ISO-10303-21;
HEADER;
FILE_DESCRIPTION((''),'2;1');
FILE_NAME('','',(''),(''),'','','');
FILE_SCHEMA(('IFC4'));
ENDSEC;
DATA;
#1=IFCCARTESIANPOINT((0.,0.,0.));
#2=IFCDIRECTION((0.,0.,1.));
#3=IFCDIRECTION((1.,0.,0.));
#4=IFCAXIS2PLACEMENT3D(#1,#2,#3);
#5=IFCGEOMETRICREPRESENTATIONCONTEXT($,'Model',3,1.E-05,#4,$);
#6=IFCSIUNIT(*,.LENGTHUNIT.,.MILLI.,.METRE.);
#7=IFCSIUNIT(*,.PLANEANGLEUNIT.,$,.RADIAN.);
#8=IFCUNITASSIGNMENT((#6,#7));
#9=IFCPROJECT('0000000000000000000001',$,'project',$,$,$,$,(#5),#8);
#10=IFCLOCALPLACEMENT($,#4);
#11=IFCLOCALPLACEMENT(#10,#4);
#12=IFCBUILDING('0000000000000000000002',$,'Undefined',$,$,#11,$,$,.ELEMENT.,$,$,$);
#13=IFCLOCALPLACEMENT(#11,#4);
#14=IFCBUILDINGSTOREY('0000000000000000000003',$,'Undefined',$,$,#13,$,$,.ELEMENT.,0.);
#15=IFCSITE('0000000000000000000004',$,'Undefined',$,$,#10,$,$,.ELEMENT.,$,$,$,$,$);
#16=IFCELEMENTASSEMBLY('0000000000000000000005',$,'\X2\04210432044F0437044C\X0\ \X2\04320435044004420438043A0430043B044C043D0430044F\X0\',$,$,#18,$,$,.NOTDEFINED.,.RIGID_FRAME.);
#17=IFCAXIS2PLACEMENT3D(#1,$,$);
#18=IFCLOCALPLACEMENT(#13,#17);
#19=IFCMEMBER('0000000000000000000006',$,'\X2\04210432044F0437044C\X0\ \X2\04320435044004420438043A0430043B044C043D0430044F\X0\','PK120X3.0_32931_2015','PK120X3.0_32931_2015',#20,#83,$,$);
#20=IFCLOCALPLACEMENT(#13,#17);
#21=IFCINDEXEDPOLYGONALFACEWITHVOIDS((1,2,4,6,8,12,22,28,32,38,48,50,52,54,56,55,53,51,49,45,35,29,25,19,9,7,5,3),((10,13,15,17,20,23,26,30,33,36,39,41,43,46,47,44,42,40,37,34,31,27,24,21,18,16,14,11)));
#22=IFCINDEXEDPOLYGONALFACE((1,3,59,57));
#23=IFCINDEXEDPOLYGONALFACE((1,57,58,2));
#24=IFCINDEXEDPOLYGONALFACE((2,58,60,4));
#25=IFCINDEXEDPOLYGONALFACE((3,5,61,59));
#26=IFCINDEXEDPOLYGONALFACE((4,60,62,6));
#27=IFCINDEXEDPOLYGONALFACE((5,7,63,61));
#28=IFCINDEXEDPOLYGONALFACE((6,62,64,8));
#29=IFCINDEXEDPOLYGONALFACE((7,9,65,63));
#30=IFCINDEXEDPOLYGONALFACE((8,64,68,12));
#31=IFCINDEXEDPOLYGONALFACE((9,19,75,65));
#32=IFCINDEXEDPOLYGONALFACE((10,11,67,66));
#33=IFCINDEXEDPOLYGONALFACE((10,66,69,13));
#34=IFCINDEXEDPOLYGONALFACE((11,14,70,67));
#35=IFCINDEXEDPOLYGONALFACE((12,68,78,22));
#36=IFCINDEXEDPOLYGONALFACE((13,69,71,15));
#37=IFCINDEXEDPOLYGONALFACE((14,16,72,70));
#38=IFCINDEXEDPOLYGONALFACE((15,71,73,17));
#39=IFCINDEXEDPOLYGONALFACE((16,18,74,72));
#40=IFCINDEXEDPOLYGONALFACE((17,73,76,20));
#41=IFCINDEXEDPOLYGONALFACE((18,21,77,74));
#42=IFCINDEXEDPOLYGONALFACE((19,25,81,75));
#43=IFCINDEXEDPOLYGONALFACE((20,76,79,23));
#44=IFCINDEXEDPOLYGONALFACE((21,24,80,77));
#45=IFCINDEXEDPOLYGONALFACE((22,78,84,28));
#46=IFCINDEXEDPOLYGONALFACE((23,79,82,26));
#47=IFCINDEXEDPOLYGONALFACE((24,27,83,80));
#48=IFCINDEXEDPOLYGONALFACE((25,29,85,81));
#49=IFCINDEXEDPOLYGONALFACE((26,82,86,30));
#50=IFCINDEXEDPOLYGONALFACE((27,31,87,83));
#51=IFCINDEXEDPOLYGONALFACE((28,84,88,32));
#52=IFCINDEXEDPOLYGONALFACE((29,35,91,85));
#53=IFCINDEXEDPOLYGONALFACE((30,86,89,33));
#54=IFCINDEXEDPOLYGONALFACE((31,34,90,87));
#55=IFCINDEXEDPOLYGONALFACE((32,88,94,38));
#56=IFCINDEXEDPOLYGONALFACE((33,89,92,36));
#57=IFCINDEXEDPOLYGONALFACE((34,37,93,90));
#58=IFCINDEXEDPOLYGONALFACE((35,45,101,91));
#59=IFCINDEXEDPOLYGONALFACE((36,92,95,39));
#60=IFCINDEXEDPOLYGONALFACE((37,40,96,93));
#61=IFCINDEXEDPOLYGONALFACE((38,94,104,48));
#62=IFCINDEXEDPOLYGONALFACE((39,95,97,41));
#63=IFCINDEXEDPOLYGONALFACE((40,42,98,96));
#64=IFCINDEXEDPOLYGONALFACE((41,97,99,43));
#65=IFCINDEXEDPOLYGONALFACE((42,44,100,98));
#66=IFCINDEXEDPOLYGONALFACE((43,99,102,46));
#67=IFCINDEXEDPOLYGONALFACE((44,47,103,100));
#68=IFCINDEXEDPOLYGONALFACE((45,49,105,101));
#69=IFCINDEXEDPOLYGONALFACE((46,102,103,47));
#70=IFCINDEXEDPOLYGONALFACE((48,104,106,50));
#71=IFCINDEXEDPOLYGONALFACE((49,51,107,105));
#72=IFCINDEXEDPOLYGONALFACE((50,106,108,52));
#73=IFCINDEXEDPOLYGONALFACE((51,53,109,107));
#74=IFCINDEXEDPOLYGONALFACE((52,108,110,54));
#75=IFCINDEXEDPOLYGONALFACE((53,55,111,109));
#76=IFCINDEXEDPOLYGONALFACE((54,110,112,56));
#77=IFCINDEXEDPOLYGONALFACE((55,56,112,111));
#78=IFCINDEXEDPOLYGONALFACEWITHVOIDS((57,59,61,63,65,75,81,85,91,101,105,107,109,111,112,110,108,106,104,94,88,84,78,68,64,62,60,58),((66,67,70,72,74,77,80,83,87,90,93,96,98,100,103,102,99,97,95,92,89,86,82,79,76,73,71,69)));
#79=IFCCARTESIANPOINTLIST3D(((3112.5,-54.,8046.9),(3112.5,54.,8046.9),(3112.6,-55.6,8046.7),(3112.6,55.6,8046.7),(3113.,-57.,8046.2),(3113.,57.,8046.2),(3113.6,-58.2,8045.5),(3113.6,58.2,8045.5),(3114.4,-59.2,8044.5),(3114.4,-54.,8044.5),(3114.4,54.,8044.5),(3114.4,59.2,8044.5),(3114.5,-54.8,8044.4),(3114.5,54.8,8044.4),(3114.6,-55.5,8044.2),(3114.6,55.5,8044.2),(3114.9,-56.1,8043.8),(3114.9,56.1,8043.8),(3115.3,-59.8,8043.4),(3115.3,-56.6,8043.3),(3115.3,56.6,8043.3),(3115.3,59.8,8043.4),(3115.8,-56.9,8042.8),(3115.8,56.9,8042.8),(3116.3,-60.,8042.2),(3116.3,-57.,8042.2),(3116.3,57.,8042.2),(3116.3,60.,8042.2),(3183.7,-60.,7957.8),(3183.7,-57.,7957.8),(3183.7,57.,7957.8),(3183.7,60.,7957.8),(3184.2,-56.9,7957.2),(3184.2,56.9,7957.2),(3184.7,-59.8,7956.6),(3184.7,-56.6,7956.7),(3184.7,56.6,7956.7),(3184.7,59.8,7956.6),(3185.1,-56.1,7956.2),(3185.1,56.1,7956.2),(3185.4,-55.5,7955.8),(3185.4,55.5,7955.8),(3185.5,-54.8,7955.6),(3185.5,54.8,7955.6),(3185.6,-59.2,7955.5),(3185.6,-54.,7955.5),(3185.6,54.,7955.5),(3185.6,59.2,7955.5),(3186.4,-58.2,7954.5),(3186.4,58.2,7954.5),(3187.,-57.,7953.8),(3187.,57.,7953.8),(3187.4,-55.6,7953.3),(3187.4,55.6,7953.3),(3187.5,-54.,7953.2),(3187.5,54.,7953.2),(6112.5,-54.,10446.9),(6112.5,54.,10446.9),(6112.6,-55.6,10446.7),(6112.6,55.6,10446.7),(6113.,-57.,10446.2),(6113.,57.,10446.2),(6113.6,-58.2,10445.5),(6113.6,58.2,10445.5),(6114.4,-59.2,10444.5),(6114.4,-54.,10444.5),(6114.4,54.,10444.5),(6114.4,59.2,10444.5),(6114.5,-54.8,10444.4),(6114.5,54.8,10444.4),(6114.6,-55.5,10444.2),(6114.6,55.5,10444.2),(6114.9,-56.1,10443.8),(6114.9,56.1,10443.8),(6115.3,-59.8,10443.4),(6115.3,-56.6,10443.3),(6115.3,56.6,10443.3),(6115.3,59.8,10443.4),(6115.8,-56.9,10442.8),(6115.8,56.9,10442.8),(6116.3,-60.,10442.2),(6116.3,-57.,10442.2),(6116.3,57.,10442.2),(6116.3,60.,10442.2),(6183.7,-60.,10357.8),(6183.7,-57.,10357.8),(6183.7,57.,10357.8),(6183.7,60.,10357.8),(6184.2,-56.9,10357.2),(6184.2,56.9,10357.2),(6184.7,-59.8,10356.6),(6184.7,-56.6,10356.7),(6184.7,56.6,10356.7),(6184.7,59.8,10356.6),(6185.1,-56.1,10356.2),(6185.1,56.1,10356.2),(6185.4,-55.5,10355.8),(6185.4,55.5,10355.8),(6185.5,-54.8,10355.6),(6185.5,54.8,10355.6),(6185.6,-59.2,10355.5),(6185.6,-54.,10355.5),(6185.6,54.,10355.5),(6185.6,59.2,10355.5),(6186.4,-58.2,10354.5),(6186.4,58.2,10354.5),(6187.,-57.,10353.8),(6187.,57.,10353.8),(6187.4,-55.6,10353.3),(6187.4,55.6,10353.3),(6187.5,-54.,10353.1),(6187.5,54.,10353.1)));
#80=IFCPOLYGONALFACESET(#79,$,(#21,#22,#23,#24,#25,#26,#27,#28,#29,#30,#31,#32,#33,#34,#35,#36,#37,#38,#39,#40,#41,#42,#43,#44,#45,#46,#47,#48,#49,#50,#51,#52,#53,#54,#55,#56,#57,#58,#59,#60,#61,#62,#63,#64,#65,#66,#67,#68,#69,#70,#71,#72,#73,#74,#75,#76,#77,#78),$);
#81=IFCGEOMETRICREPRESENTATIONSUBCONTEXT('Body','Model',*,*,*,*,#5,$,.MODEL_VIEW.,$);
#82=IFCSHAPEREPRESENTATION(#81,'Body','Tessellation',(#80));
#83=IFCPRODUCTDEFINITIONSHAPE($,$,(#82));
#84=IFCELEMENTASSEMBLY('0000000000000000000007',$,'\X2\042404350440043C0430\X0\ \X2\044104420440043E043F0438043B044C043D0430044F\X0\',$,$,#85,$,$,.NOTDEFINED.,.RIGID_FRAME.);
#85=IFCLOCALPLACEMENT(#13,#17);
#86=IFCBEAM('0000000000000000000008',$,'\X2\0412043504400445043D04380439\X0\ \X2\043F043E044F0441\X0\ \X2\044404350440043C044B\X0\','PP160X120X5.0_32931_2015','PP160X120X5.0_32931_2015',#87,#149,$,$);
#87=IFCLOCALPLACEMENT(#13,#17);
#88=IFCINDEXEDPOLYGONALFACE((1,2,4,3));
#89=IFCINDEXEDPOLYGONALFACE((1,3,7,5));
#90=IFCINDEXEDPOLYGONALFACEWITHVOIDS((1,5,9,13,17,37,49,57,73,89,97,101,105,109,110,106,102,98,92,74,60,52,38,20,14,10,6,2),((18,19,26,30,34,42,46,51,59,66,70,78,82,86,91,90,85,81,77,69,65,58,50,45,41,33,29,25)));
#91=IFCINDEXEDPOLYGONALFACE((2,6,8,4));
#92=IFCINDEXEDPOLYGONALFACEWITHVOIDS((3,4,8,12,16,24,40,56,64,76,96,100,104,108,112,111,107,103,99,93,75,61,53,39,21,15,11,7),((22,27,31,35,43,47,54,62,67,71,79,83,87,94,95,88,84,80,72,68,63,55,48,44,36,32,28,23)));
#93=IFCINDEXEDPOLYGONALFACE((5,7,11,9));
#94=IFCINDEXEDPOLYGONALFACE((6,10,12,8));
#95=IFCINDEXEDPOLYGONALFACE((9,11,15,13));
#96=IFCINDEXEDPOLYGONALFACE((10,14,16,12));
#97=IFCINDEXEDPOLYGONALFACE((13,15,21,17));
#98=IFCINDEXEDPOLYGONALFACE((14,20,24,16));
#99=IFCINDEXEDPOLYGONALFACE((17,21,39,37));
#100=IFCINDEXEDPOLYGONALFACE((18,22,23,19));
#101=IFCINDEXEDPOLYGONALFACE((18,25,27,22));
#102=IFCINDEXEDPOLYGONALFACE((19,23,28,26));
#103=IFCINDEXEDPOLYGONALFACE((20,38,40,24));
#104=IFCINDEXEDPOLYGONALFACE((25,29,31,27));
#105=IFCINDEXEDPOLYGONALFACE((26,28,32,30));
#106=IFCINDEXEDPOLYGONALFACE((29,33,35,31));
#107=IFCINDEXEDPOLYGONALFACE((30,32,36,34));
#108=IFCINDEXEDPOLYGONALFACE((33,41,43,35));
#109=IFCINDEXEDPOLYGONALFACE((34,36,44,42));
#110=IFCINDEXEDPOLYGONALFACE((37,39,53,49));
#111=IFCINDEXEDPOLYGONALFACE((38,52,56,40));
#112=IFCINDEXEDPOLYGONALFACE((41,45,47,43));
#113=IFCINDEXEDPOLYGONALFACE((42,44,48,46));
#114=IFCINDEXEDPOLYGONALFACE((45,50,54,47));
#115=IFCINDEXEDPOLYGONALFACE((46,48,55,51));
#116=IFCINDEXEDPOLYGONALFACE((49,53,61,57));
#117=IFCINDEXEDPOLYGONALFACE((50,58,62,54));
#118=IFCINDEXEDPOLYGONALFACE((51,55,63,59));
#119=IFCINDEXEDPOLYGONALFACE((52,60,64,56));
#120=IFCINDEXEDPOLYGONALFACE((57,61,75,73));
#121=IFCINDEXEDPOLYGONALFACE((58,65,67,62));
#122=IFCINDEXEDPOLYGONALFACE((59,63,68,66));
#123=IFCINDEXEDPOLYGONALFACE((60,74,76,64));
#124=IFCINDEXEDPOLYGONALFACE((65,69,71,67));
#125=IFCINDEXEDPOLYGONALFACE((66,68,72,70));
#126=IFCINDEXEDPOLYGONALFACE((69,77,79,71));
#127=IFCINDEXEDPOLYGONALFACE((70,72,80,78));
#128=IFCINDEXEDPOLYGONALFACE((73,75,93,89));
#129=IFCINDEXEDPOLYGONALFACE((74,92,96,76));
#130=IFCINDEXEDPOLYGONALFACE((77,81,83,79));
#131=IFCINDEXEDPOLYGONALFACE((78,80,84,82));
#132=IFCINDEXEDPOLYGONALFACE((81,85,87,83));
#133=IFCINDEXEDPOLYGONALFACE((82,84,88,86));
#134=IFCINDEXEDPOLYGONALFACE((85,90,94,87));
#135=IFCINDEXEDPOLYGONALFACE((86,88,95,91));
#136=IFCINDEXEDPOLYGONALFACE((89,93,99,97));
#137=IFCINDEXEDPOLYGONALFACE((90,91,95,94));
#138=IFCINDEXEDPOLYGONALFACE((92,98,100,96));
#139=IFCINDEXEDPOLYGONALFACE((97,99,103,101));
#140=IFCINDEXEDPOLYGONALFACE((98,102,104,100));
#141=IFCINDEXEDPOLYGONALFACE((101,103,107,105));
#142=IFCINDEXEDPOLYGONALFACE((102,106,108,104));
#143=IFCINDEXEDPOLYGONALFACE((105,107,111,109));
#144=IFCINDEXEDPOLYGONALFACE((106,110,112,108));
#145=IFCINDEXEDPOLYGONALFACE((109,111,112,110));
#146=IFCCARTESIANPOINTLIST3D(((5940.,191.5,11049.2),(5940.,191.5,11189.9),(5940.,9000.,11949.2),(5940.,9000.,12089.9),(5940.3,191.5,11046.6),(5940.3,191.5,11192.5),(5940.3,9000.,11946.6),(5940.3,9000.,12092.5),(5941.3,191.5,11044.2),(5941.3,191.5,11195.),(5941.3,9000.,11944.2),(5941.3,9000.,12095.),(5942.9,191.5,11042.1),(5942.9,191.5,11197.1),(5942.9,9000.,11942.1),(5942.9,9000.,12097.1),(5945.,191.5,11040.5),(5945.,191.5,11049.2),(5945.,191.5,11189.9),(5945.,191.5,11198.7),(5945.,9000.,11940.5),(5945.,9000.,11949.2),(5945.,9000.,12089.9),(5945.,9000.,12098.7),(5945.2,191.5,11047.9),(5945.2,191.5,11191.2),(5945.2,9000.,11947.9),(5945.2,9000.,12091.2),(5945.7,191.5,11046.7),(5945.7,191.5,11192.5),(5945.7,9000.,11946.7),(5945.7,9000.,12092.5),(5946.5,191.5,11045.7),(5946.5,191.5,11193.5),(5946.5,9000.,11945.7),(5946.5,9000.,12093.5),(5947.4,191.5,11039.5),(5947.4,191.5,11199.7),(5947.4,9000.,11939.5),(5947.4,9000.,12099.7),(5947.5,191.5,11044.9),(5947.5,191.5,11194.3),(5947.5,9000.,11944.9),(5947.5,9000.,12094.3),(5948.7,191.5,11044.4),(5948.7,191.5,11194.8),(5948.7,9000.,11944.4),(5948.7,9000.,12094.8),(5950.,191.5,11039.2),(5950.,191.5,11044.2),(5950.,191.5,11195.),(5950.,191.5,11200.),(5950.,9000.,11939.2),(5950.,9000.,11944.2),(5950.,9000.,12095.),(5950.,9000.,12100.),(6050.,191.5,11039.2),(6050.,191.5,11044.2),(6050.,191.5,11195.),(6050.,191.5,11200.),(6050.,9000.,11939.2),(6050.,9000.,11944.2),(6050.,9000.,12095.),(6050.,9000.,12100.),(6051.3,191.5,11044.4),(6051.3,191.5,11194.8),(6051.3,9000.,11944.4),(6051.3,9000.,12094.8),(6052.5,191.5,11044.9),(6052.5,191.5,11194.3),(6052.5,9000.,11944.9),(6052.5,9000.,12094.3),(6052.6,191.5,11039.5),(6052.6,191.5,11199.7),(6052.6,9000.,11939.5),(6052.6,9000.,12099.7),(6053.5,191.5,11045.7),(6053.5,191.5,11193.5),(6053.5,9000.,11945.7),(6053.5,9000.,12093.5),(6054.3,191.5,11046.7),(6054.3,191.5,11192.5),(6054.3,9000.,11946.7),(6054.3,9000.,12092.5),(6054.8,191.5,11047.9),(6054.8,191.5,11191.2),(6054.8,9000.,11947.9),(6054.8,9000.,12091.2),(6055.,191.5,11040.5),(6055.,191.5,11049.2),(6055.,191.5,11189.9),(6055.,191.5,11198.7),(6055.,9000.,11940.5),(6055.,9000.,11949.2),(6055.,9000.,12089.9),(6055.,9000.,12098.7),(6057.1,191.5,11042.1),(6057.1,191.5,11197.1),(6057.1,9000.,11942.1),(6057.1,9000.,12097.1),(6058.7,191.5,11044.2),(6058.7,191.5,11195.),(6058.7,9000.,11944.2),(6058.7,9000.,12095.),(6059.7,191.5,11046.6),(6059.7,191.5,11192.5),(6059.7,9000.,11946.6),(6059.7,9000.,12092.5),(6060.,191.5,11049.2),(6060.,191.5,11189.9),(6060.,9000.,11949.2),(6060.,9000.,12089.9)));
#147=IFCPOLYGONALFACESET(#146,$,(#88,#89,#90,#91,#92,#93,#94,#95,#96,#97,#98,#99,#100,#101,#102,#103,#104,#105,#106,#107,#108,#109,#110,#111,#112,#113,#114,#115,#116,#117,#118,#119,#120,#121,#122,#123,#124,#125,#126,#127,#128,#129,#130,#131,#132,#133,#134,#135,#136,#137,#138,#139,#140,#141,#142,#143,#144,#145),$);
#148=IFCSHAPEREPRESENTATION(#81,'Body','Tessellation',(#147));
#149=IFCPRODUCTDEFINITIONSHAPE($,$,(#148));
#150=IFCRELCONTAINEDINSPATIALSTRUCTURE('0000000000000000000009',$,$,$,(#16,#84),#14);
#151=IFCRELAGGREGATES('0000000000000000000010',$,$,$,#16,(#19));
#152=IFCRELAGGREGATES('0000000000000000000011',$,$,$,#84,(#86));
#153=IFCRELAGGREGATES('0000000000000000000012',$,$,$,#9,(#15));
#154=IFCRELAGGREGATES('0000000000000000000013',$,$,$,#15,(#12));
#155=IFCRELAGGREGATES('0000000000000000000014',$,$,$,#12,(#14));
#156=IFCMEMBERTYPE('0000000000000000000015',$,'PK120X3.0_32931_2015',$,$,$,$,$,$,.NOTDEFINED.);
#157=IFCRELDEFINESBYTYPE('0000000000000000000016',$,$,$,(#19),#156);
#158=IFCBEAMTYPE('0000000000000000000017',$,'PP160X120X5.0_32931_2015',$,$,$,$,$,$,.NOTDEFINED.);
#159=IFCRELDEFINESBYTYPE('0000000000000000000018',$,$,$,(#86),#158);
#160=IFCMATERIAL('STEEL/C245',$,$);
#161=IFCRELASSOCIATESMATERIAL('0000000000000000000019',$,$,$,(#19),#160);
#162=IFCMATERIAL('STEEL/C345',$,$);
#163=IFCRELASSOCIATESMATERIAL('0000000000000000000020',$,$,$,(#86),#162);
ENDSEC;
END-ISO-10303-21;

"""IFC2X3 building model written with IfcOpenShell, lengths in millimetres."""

from ifc_helpers import new_model, si_unit, frame, origin_with_axes, origin_2d_with_axis, place, context, subcontext, project, spatial, hollow_rectangle, extrude, clip, halfspace, material, type_object, element, aggregate, save


model = new_model("IFC2X3")

# Units and contexts
model_context = context("Model", 3, precision=1e-05, world=origin_with_axes())
body_context = subcontext(model_context, "Body", "Model", "MODEL_VIEW")
ifc_project = project(units=[si_unit("LENGTHUNIT", "METRE", prefix="MILLI"), si_unit("PLANEANGLEUNIT", "RADIAN")], contexts=[model_context])

# Site, building, storey
site_placement = place(None, origin_with_axes())
site = spatial("IfcSite", under=ifc_project, at=site_placement, Name="Undefined", CompositionType="ELEMENT")
building_placement = place(site_placement, origin_with_axes())
building = spatial("IfcBuilding", under=site, at=building_placement, Name="Undefined", CompositionType="ELEMENT")
storey_placement = place(building_placement, origin_with_axes())
storey = spatial("IfcBuildingStorey", under=building, at=storey_placement, Name="Undefined", CompositionType="ELEMENT", Elevation=0.0)

# Shared definitions
ifc_material_1 = material(Name="STEEL/C245")

# Shared definitions
ifc_material_2 = material(Name="STEEL/C345")

# Element assembly, member
member_type = type_object("IfcMemberType", Name="PK120X3.0_32931_2015", PredefinedType="NOTDEFINED")
assembly_1_placement = place(storey_placement, origin_with_axes())
assembly_1 = element("IfcElementAssembly", 1, at=assembly_1_placement, inside=storey, Name="Связь вертикальная", AssemblyPlace="NOTDEFINED", PredefinedType="RIGID_FRAME")
member_1_placement = place(assembly_1_placement, frame((3150.0, 0.0, 8000.0), z_axis=(-0.624695, 0.0, 0.780869), x_axis=(0.780869, 0.0, 0.624695)))
member_1 = element("IfcMember", 2, at=member_1_placement, type_object=member_type, material=ifc_material_1, Name="Связь вертикальная", Description="PK120X3.0_32931_2015", ObjectType="PK120X3.0_32931_2015", context=body_context, shape_type="SweptSolid", body=[
    extrude(hollow_rectangle(XDim=120.0, YDim=120.0, WallThickness=3.0, InnerFilletRadius=3.0, OuterFilletRadius=6.0, at=origin_2d_with_axis()), frame((3841.9, 0.0, 0.0), z_axis=(-1.0, 0.0, 0.0), x_axis=(0.0, -1.0, 0.0)), (0.0, 0.0, 1.0), 3841.9),
])
aggregate(assembly_1, [member_1])

# Element assembly, beam
assembly_2_placement = place(storey_placement, origin_with_axes())
assembly_2 = element("IfcElementAssembly", 3, at=assembly_2_placement, inside=storey, Name="Ферма стропильная", AssemblyPlace="NOTDEFINED", PredefinedType="RIGID_FRAME")
beam_type_1 = type_object("IfcBeamType", Name="PP160X120X5.0_32931_2015", PredefinedType="NOTDEFINED")
beam_1_placement = place(assembly_2_placement, frame((6000.0, 199.6, 11120.4), z_axis=(0.0, -0.101645, 0.994821), x_axis=(0.0, 0.994821, 0.101645)))
beam_1 = element("IfcBeam", 4, at=beam_1_placement, type_object=beam_type_1, material=ifc_material_2, Name="Верхний пояс фермы", Description="PP160X120X5.0_32931_2015", ObjectType="PP160X120X5.0_32931_2015", context=body_context, shape_type="Clipping", body=[
    clip(clip(extrude(hollow_rectangle(XDim=120.0, YDim=160.0, WallThickness=5.0, InnerFilletRadius=5.0, OuterFilletRadius=10.0, at=origin_2d_with_axis()), frame((8862.7, 0.0, 0.0), z_axis=(-1.0, 0.0, 0.0), x_axis=(0.0, -1.0, 0.0)), (0.0, 0.0, 1.0), 8887.4), halfspace(frame((8854.4, 0.0, 80.0), z_axis=(0.994821, 0.0, -0.101645), x_axis=(0.0, -1.0, 0.0)), False)), halfspace(frame((0.0, 0.0, 80.0), z_axis=(0.994821, 0.0, -0.101645), x_axis=(0.0, -1.0, 0.0)), True)),
])

aggregate(assembly_2, [beam_1])

save(model, "model.ifc")
